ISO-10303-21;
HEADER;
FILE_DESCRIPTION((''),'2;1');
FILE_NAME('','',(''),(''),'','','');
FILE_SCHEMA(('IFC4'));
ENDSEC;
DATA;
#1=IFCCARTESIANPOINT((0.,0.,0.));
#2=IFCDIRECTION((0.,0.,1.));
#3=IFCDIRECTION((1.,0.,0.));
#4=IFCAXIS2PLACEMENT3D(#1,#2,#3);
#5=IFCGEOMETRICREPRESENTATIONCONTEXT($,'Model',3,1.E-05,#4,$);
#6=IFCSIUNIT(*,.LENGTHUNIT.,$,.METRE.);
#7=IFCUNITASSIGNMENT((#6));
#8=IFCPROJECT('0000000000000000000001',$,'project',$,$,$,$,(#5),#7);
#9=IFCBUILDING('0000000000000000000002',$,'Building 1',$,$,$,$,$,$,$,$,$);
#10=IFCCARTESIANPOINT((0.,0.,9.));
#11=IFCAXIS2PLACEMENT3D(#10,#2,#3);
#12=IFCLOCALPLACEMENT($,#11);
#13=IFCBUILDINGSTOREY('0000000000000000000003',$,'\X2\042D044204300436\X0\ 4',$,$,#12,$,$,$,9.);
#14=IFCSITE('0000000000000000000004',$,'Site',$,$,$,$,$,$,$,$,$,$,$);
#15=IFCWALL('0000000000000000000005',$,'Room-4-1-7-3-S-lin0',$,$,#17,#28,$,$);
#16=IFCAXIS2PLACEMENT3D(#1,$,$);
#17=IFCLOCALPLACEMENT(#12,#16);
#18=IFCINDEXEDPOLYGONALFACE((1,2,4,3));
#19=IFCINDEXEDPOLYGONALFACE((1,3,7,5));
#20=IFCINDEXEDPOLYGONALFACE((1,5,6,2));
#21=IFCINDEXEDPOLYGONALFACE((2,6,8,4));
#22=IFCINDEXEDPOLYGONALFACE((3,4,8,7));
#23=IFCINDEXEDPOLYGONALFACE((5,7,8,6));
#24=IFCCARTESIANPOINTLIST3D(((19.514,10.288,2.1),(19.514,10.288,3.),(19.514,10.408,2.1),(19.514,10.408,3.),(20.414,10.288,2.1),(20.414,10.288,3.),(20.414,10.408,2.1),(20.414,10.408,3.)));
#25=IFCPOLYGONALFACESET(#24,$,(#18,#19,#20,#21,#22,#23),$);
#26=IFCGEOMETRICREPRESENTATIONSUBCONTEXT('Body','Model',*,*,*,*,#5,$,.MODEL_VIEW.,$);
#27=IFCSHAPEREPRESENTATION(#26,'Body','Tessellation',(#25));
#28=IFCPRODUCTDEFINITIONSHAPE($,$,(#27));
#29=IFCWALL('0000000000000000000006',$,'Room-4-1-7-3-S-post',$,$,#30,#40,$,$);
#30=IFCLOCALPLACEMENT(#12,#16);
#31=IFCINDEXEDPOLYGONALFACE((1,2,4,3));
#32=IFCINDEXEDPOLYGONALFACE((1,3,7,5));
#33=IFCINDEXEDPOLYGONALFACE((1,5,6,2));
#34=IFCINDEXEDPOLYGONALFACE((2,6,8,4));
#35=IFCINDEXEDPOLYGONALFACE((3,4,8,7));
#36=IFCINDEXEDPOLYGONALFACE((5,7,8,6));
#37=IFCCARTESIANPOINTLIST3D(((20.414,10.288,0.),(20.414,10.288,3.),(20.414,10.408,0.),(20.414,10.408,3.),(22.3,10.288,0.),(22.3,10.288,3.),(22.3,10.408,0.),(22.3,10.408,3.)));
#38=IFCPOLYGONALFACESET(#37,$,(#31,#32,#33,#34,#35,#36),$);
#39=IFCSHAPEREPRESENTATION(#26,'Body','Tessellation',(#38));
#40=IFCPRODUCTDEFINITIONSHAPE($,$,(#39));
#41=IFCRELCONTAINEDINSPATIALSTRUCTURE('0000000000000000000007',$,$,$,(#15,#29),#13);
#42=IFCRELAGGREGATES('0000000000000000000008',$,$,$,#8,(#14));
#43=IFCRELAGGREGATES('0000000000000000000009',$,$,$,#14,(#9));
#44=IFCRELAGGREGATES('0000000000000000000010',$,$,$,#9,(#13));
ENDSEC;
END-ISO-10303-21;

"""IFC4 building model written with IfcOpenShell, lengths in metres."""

from ifc_helpers import new_model, si_unit, frame, origin_with_axes, place, context, subcontext, project, spatial, indexed_curve, outline, extrude, element, save


model = new_model("IFC4")

# Units and contexts
model_context = context("Model", 3, precision=1e-05, world=origin_with_axes())
body_context = subcontext(model_context, "Body", "Model", "MODEL_VIEW")
ifc_project = project(units=[si_unit("LENGTHUNIT", "METRE")], contexts=[model_context])

# Site, building, storey
site = spatial("IfcSite", under=ifc_project, Name="Site")
building = spatial("IfcBuilding", under=site, Name="Building 1")
storey_placement = place(None, frame((0.0, 0.0, 9.0), z_axis=(0.0, 0.0, 1.0), x_axis=(1.0, 0.0, 0.0)))
storey = spatial("IfcBuildingStorey", under=building, at=storey_placement, Name="Этаж 4", Elevation=9.0)

# Walls
wall_1_placement = place(storey_placement, frame((19.514, 10.288, 2.1), z_axis=(0.0, 0.0, 1.0), x_axis=(1.0, 0.0, 0.0)))
element("IfcWall", 1, at=wall_1_placement, inside=storey, Name="Room-4-1-7-3-S-lin0", context=body_context, shape_type="SweptSolid", body=[
    extrude(outline(indexed_curve([(0.0, 0.0), (0.0, 0.12), (0.9, 0.12), (0.9, 0.0), (0.0, 0.0)], self_intersect=False)), origin_with_axes(), (0.0, 0.0, 1.0), 0.9),
])
wall_2_placement = place(storey_placement, frame((20.414, 10.288, 0.0), z_axis=(0.0, 0.0, 1.0), x_axis=(1.0, 0.0, 0.0)))
element("IfcWall", 2, at=wall_2_placement, inside=storey, Name="Room-4-1-7-3-S-post", context=body_context, shape_type="SweptSolid", body=[
    extrude(outline(indexed_curve([(0.0, 0.0), (0.0, 0.12), (1.886, 0.12), (1.886, 0.0), (0.0, 0.0)], self_intersect=False)), origin_with_axes(), (0.0, 0.0, 1.0), 3.0),
])

save(model, "model.ifc")
